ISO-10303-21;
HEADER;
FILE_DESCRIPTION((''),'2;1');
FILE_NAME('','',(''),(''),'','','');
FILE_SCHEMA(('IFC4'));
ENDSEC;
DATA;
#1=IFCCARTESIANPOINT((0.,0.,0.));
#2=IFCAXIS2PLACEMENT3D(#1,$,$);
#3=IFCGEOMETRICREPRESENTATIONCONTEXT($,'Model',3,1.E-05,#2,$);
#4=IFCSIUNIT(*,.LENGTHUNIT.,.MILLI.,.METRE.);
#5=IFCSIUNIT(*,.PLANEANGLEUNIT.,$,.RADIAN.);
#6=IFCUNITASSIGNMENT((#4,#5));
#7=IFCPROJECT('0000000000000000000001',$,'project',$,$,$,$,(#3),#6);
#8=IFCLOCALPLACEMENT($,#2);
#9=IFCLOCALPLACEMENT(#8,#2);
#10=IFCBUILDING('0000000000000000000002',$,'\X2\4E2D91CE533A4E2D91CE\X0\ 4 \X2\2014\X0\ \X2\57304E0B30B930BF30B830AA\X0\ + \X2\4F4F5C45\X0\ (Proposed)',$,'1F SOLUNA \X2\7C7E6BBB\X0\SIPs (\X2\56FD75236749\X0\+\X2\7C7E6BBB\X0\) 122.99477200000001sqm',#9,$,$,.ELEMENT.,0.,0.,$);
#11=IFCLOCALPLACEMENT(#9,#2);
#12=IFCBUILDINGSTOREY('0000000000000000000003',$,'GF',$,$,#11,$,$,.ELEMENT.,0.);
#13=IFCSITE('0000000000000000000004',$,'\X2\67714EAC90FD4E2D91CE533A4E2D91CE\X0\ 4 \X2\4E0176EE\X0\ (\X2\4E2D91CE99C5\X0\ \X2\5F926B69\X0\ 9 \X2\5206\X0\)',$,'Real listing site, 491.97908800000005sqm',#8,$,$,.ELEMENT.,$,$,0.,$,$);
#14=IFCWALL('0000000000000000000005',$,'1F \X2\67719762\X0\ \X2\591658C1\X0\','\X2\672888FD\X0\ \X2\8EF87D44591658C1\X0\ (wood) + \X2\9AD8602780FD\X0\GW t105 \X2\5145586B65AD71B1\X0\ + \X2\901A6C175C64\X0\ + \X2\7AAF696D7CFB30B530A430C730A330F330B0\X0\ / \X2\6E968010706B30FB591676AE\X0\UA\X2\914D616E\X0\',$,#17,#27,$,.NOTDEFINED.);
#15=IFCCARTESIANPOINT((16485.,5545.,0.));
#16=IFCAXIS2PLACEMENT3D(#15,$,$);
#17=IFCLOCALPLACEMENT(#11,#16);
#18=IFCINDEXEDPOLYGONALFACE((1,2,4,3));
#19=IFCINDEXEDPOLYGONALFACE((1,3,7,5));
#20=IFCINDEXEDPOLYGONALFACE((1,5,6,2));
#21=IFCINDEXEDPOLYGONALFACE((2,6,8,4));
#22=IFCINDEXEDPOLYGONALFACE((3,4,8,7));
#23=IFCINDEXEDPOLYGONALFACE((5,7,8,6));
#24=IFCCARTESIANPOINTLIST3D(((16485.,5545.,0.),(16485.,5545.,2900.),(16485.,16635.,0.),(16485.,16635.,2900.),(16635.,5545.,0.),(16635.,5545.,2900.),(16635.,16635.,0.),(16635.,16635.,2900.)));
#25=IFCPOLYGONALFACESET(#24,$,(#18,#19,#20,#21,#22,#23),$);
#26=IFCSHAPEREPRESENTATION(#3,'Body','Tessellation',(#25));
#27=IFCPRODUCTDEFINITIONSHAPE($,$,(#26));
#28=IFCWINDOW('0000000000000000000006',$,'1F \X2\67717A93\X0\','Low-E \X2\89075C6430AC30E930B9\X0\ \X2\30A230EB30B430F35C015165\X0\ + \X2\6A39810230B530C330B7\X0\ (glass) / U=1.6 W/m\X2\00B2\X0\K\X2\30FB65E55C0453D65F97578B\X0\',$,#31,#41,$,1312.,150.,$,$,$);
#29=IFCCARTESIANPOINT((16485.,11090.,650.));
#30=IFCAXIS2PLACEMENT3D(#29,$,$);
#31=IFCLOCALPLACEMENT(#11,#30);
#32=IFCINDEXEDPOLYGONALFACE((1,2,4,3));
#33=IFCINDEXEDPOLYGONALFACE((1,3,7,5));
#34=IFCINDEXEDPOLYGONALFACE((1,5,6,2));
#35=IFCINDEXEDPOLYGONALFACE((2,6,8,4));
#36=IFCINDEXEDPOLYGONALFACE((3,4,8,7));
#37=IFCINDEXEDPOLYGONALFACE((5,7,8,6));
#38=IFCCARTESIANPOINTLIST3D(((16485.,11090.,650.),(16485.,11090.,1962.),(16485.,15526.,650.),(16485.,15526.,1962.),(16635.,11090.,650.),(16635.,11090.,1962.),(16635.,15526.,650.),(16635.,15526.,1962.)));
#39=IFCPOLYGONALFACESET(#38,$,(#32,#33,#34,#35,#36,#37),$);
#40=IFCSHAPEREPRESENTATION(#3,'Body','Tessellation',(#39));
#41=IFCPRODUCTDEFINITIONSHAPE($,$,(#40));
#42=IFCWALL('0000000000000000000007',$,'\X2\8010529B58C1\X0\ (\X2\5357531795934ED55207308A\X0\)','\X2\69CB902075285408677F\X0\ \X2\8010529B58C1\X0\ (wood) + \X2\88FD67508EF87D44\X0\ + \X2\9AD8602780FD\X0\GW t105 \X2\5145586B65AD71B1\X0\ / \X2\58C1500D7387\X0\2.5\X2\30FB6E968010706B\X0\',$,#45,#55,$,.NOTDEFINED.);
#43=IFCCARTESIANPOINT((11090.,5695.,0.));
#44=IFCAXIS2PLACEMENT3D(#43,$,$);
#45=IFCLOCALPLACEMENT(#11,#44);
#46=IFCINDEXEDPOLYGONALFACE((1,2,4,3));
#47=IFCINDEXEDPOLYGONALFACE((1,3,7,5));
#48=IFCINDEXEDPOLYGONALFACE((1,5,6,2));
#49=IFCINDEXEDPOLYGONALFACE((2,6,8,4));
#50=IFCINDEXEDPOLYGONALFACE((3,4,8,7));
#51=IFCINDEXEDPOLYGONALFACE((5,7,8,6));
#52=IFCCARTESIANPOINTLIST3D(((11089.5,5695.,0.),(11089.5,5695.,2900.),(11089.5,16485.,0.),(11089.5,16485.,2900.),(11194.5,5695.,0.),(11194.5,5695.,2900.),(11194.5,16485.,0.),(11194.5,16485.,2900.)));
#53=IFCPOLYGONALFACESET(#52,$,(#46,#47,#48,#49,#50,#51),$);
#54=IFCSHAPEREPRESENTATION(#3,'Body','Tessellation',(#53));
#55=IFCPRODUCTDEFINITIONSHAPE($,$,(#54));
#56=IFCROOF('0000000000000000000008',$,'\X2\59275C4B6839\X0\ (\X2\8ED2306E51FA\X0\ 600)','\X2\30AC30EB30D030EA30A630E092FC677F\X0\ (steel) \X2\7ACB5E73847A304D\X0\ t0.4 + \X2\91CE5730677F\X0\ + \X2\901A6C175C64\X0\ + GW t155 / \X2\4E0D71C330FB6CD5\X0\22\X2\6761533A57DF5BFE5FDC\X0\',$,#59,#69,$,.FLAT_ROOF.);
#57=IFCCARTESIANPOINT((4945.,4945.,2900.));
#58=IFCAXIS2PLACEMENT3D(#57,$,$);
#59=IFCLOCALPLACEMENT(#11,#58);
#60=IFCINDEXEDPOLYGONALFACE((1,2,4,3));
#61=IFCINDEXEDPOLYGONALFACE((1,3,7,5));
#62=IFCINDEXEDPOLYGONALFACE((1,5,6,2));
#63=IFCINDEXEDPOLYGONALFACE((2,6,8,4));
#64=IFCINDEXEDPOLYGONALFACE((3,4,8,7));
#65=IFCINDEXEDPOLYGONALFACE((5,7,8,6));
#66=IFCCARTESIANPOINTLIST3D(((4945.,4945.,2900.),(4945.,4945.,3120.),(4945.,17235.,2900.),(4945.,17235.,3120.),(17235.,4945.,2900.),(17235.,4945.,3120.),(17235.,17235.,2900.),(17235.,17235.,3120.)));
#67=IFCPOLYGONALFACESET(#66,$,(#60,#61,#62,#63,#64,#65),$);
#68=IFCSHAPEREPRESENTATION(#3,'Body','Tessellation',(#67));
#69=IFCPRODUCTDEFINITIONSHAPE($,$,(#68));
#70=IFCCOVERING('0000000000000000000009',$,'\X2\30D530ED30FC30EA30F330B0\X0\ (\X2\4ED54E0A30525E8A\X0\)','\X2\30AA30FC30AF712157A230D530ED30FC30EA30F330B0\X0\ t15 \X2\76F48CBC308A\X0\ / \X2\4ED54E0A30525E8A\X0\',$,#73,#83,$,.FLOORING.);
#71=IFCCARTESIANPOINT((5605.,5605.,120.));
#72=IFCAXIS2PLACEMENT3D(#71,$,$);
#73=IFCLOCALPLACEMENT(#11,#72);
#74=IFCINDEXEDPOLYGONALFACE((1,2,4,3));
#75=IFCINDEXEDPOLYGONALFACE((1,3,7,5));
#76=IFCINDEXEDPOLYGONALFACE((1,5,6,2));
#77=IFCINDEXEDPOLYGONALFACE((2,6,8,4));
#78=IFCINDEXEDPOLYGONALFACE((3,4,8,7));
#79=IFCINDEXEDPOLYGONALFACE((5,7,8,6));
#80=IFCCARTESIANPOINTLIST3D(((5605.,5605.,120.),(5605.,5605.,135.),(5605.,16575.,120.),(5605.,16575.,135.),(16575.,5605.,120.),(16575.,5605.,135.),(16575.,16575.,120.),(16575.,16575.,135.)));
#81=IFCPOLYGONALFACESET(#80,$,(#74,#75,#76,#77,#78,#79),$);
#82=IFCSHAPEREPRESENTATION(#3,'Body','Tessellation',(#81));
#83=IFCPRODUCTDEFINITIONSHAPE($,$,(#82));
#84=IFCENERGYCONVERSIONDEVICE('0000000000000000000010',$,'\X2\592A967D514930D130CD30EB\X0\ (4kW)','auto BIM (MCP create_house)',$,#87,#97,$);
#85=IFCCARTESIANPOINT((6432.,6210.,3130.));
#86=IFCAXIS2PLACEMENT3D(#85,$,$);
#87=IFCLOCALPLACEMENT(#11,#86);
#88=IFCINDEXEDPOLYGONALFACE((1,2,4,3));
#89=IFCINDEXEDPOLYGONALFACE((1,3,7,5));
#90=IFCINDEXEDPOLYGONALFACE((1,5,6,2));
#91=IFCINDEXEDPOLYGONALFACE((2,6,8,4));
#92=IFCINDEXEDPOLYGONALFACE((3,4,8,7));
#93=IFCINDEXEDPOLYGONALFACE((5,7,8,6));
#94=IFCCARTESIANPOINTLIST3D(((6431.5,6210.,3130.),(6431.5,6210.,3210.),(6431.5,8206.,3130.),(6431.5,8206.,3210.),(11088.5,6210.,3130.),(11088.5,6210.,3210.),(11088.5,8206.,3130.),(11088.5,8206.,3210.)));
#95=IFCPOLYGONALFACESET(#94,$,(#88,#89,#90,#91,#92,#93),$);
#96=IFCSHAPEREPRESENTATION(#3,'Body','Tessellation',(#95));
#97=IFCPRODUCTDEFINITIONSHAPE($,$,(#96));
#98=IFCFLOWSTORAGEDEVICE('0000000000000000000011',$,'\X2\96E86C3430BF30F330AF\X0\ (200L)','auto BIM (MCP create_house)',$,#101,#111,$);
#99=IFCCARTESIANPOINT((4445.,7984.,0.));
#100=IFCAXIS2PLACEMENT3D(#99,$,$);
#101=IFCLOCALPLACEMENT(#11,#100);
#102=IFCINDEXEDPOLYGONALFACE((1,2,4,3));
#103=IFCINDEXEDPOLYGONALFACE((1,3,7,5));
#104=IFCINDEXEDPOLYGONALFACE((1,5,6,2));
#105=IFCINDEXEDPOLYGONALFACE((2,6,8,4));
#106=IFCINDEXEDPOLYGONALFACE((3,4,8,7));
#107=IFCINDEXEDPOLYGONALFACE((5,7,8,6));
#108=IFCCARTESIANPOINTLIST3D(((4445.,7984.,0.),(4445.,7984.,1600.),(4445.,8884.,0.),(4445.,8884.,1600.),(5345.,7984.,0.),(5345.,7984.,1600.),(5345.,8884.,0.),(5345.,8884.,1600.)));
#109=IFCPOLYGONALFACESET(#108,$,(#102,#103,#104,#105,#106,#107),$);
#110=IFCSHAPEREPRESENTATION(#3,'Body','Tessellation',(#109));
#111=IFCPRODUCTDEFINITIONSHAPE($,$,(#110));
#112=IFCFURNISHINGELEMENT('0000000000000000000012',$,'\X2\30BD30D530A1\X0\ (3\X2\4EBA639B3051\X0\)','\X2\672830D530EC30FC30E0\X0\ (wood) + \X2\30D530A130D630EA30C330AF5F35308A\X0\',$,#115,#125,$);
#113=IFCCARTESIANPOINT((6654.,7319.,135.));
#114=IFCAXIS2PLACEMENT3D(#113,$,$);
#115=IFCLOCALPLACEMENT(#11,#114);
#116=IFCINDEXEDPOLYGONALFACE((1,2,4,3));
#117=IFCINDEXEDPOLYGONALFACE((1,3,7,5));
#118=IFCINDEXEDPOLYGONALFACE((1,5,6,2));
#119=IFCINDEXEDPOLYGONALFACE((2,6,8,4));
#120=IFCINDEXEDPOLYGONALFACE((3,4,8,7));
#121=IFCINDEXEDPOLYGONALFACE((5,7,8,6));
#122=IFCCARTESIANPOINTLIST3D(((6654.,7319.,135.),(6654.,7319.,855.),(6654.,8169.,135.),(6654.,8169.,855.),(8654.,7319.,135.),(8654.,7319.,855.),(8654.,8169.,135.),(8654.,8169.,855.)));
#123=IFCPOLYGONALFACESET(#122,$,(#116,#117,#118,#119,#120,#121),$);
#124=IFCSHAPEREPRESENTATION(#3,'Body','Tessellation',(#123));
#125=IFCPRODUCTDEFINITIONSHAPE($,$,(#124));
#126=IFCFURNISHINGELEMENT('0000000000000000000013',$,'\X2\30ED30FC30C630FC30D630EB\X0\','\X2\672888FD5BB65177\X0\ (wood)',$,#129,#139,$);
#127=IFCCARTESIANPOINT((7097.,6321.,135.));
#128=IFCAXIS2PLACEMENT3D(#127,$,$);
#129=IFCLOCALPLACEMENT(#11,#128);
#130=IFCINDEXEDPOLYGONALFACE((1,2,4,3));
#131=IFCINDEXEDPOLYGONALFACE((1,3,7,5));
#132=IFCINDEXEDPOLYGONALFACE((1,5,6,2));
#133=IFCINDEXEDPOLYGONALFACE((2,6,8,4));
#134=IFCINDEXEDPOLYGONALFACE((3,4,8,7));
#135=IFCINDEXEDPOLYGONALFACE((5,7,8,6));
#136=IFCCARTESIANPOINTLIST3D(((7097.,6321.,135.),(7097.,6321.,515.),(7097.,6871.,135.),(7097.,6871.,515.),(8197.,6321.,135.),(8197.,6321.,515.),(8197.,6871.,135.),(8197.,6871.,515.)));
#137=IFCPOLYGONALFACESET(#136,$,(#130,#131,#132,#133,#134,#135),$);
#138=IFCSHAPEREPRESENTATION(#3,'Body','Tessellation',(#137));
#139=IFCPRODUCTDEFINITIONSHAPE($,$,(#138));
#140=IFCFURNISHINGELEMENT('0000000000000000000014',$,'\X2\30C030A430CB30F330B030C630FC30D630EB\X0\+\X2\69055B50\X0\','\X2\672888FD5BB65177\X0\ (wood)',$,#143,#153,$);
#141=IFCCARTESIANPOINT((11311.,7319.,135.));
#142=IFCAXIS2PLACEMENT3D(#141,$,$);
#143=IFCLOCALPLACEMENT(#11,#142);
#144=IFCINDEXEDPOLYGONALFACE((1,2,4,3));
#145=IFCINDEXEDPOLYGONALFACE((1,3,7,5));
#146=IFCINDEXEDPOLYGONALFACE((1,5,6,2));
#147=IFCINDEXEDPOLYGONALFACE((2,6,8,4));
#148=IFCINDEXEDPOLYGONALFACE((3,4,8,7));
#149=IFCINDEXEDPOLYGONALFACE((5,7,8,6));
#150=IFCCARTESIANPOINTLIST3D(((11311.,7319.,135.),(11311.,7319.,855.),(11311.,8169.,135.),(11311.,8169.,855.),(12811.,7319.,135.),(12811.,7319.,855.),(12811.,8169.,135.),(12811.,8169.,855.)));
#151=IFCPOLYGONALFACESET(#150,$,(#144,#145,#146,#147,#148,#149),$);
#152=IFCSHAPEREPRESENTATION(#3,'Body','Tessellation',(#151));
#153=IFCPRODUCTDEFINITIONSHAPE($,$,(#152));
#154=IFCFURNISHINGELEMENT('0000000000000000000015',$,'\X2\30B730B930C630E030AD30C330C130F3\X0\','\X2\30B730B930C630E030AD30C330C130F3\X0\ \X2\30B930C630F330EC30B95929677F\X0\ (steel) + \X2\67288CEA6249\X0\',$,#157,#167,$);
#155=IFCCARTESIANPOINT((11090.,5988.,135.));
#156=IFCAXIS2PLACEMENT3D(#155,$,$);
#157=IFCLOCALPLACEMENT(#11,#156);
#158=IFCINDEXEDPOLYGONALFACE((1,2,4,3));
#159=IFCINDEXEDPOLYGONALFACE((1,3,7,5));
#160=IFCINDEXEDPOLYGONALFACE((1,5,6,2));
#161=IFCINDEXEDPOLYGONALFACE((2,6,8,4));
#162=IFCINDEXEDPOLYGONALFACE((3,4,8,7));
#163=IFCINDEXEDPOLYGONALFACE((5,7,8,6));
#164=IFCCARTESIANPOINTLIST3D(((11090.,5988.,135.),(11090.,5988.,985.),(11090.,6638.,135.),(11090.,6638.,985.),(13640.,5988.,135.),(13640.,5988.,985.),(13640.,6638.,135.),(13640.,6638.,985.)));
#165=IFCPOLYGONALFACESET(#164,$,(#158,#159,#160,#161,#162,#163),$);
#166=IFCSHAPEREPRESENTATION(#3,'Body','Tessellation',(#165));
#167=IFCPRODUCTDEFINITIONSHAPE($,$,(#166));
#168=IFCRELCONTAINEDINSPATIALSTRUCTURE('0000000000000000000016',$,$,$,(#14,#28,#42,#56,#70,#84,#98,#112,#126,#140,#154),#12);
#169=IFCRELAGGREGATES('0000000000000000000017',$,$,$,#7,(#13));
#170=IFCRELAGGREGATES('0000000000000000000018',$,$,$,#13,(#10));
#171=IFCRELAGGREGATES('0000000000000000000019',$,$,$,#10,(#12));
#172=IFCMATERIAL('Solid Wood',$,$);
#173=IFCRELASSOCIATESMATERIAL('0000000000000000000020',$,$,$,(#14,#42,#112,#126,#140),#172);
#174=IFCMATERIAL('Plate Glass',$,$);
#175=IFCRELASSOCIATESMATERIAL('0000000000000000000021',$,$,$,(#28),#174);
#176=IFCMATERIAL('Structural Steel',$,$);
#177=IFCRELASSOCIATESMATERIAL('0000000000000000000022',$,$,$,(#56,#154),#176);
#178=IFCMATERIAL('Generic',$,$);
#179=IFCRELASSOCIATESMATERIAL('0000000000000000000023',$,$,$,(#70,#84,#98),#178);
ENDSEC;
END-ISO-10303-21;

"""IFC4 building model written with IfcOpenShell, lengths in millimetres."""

from ifc_helpers import new_model, si_unit, frame, frame_2d, origin, place, context, project, spatial, rectangle, extrude, material, element, fill, save


model = new_model("IFC4")

# Units and contexts
model_context = context("Model", 3, precision=1e-05, world=origin())
ifc_project = project(units=[si_unit("LENGTHUNIT", "METRE", prefix="MILLI"), si_unit("PLANEANGLEUNIT", "RADIAN")], contexts=[model_context])

# Site, building, storey
site_placement = place(None, origin())
site = spatial("IfcSite", under=ifc_project, at=site_placement, Name="東京都中野区中野 4 丁目 (中野駅 徒歩 9 分)", ObjectType="Real listing site, 491.97908800000005sqm", CompositionType="ELEMENT", RefElevation=0.0)
building_placement = place(site_placement, origin())
building = spatial("IfcBuilding", under=site, at=building_placement, Name="中野区中野 4 — 地下スタジオ + 住居 (Proposed)", ObjectType="1F SOLUNA 籾殻SIPs (国産杉+籾殻) 122.99477200000001sqm", CompositionType="ELEMENT", ElevationOfRefHeight=0.0, ElevationOfTerrain=0.0)
storey_placement = place(building_placement, origin())
storey = spatial("IfcBuildingStorey", under=building, at=storey_placement, Name="GF", CompositionType="ELEMENT", Elevation=0.0)

# Shared definitions
ifc_material_1 = material(Name="Solid Wood")

# Shared definitions
ifc_material_2 = material(Name="Plate Glass")

# Wall, opening, window
wall_1_placement = place(storey_placement, frame((16485.0, 5545.0, 0.0)))
wall_1 = element("IfcWall", 1, at=wall_1_placement, inside=storey, material=ifc_material_1, Name="1F 東面 外壁", Description="木製 軸組外壁 (wood) + 高性能GW t105 充填断熱 + 通気層 + 窯業系サイディング / 準耐火・外皮UA配慮", PredefinedType="NOTDEFINED", context=model_context, shape_type="SweptSolid", body=[
    extrude(rectangle(XDim=150.0, YDim=11090.0, at=frame_2d((75.0, 5545.0))), frame((16485.0, 5545.0, 0.0)), (0.0, 0.0, 1.0), 2900.0),
])
opening_1_placement = place(storey_placement, frame((16485.0, 11090.0, 650.0)))
opening_1 = element("IfcOpeningElement", 2, at=opening_1_placement, cuts=wall_1, PredefinedType="NOTDEFINED", context=model_context, shape_type="SweptSolid", body=[
    extrude(rectangle(XDim=150.0, YDim=4436.0, at=frame_2d((75.0, 2218.0))), frame((16485.0, 11090.0, 650.0)), (0.0, 0.0, 1.0), 1312.0),
])
window_1_placement = place(storey_placement, frame((16485.0, 11090.0, 650.0)))
window_1 = element("IfcWindow", 3, at=window_1_placement, inside=storey, material=ifc_material_2, Name="1F 東窓", Description="Low-E 複層ガラス アルゴン封入 + 樹脂サッシ (glass) / U=1.6 W/m²K・日射取得型", OverallHeight=1312.0, OverallWidth=150.0, context=model_context, shape_type="SweptSolid", body=[
    extrude(rectangle(XDim=150.0, YDim=4436.0, at=frame_2d((75.0, 2218.0))), frame((16485.0, 11090.0, 650.0)), (0.0, 0.0, 1.0), 1312.0),
])
fill(opening_1, window_1)

# Wall
wall_2_placement = place(storey_placement, frame((11090.0, 5695.0, 0.0)))
element("IfcWall", 4, at=wall_2_placement, inside=storey, material=ifc_material_1, Name="耐力壁 (南北間仕切り)", Description="構造用合板 耐力壁 (wood) + 製材軸組 + 高性能GW t105 充填断熱 / 壁倍率2.5・準耐火", PredefinedType="NOTDEFINED", context=model_context, shape_type="SweptSolid", body=[
    extrude(rectangle(XDim=105.0, YDim=10790.0, at=frame_2d((52.0, 5395.0))), frame((11090.0, 5695.0, 0.0)), (0.0, 0.0, 1.0), 2900.0),
])

# Roof
ifc_material_3 = material(Name="Structural Steel")
roof_placement = place(storey_placement, frame((4945.0, 4945.0, 2900.0)))
element("IfcRoof", 5, at=roof_placement, inside=storey, material=ifc_material_3, Name="大屋根 (軒の出 600)", Description="ガルバリウム鋼板 (steel) 立平葺き t0.4 + 野地板 + 通気層 + GW t155 / 不燃・法22条区域対応", PredefinedType="FLAT_ROOF", context=model_context, shape_type="SweptSolid", body=[
    extrude(rectangle(XDim=12290.0, YDim=12290.0, at=frame_2d((6145.0, 6145.0))), frame((4945.0, 4945.0, 2900.0)), (0.0, 0.0, 1.0), 220.0),
])

# Covering
ifc_material_4 = material(Name="Generic")
covering_placement = place(storey_placement, frame((5605.0, 5605.0, 120.0)))
element("IfcCovering", 6, at=covering_placement, inside=storey, material=ifc_material_4, Name="フローリング (仕上げ床)", Description="オーク無垢フローリング t15 直貼り / 仕上げ床", PredefinedType="FLOORING", context=model_context, shape_type="SweptSolid", body=[
    extrude(rectangle(XDim=10970.0, YDim=10970.0, at=frame_2d((5485.0, 5485.0))), frame((5605.0, 5605.0, 120.0)), (0.0, 0.0, 1.0), 15.0),
])

# Energy conversion device
energy_conversion_device_placement = place(storey_placement, frame((6432.0, 6210.0, 3130.0)))
element("IfcEnergyConversionDevice", 7, at=energy_conversion_device_placement, inside=storey, material=ifc_material_4, Name="太陽光パネル (4kW)", Description="auto BIM (MCP create_house)", context=model_context, shape_type="SweptSolid", body=[
    extrude(rectangle(XDim=4657.0, YDim=1996.0, at=frame_2d((2328.0, 998.0))), frame((6432.0, 6210.0, 3130.0)), (0.0, 0.0, 1.0), 80.0),
])

# Flow storage device
flow_storage_device_placement = place(storey_placement, frame((4445.0, 7984.0, 0.0)))
element("IfcFlowStorageDevice", 8, at=flow_storage_device_placement, inside=storey, material=ifc_material_4, Name="雨水タンク (200L)", Description="auto BIM (MCP create_house)", context=model_context, shape_type="SweptSolid", body=[
    extrude(rectangle(XDim=900.0, YDim=900.0, at=frame_2d((450.0, 450.0))), frame((4445.0, 7984.0, 0.0)), (0.0, 0.0, 1.0), 1600.0),
])

# Furnishing elements
furnishing_1_placement = place(storey_placement, frame((6654.0, 7319.0, 135.0)))
element("IfcFurnishingElement", 9, at=furnishing_1_placement, inside=storey, material=ifc_material_1, Name="ソファ (3人掛け)", Description="木フレーム (wood) + ファブリック張り", context=model_context, shape_type="SweptSolid", body=[
    extrude(rectangle(XDim=2000.0, YDim=850.0, at=frame_2d((1000.0, 425.0))), frame((6654.0, 7319.0, 135.0)), (0.0, 0.0, 1.0), 720.0),
])
furnishing_2_placement = place(storey_placement, frame((7097.0, 6321.0, 135.0)))
element("IfcFurnishingElement", 10, at=furnishing_2_placement, inside=storey, material=ifc_material_1, Name="ローテーブル", Description="木製家具 (wood)", context=model_context, shape_type="SweptSolid", body=[
    extrude(rectangle(XDim=1100.0, YDim=550.0, at=frame_2d((550.0, 275.0))), frame((7097.0, 6321.0, 135.0)), (0.0, 0.0, 1.0), 380.0),
])
furnishing_3_placement = place(storey_placement, frame((11311.0, 7319.0, 135.0)))
element("IfcFurnishingElement", 11, at=furnishing_3_placement, inside=storey, material=ifc_material_1, Name="ダイニングテーブル+椅子", Description="木製家具 (wood)", context=model_context, shape_type="SweptSolid", body=[
    extrude(rectangle(XDim=1500.0, YDim=850.0, at=frame_2d((750.0, 425.0))), frame((11311.0, 7319.0, 135.0)), (0.0, 0.0, 1.0), 720.0),
])
furnishing_4_placement = place(storey_placement, frame((11090.0, 5988.0, 135.0)))
element("IfcFurnishingElement", 12, at=furnishing_4_placement, inside=storey, material=ifc_material_3, Name="システムキッチン", Description="システムキッチン ステンレス天板 (steel) + 木質扉", context=model_context, shape_type="SweptSolid", body=[
    extrude(rectangle(XDim=2550.0, YDim=650.0, at=frame_2d((1275.0, 325.0))), frame((11090.0, 5988.0, 135.0)), (0.0, 0.0, 1.0), 850.0),
])

save(model, "model.ifc")
